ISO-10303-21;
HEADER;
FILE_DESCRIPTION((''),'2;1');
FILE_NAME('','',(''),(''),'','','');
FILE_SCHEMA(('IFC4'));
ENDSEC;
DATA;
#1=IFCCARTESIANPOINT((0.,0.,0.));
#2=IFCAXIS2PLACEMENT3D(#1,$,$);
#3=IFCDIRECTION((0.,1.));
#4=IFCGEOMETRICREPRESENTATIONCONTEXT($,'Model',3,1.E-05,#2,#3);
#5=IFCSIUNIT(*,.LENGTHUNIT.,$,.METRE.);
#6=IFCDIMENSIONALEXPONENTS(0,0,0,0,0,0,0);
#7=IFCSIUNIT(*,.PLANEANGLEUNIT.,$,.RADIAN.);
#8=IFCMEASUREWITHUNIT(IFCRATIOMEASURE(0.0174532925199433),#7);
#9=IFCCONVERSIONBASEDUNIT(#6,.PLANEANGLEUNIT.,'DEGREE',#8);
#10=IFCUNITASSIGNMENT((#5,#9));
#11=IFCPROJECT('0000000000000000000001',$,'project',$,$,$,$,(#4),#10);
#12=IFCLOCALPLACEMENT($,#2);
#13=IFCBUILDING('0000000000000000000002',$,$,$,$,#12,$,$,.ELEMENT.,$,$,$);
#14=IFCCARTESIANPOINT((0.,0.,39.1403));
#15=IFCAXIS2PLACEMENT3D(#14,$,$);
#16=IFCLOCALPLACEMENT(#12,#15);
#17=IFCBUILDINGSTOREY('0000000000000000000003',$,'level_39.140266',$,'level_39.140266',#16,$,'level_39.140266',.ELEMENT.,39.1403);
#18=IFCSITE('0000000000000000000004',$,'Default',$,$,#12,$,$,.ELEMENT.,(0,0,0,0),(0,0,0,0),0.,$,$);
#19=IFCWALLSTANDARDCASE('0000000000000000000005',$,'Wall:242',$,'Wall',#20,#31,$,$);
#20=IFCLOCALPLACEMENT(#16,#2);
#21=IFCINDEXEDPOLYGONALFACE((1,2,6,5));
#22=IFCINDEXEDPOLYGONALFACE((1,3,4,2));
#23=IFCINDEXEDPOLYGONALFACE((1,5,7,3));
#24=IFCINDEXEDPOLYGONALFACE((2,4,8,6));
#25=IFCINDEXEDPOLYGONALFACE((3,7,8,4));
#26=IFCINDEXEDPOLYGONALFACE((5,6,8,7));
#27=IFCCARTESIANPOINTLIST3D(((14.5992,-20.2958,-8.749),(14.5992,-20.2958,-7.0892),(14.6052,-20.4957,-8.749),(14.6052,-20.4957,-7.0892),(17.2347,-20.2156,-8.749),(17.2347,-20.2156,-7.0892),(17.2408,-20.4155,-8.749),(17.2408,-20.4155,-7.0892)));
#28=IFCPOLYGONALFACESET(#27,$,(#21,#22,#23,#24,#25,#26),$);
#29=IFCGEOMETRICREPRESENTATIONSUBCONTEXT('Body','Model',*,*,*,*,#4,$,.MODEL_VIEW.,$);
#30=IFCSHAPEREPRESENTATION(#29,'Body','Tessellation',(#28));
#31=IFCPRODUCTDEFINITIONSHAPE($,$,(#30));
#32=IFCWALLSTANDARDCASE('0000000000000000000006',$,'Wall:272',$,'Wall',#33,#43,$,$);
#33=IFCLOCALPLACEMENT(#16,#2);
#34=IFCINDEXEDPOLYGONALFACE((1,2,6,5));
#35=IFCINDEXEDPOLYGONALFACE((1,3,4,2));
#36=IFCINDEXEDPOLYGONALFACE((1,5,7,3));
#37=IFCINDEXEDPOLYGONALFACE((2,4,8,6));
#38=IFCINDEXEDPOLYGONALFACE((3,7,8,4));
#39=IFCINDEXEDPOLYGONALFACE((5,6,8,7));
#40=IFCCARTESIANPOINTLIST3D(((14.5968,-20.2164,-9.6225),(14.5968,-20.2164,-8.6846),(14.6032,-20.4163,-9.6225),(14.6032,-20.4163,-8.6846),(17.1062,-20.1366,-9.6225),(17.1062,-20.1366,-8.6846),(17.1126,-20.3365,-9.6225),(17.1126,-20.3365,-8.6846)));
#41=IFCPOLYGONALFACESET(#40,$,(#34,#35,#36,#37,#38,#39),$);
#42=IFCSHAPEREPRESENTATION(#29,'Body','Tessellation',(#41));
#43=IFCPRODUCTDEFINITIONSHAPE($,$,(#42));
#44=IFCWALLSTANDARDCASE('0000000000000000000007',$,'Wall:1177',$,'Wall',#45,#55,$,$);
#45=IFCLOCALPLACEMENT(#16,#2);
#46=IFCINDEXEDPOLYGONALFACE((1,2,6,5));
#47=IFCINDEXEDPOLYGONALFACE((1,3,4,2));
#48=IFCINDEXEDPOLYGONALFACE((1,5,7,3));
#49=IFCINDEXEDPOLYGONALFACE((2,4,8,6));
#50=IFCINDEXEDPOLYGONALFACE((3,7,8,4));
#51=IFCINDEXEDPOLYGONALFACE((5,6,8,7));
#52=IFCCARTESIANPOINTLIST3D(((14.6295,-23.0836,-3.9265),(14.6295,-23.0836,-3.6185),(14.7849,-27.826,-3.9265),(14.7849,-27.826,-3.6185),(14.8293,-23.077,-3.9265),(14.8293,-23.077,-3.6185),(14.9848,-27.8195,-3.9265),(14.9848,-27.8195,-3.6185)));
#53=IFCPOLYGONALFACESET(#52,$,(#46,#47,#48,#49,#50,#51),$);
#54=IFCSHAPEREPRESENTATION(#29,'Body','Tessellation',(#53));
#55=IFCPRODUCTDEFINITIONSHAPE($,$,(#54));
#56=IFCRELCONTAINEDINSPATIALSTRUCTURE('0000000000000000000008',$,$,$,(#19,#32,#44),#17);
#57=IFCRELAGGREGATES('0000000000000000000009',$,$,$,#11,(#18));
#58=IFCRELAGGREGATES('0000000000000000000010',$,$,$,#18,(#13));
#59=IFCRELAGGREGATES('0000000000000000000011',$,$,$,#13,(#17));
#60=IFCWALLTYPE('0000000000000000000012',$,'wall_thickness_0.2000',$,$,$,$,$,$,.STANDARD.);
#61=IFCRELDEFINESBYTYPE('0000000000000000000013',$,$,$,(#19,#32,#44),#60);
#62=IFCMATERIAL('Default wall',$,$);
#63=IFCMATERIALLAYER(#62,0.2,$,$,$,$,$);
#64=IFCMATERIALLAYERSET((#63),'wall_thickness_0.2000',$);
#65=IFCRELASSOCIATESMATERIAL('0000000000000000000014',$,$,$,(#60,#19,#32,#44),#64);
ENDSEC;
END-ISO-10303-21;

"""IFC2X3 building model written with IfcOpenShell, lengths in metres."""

from ifc_helpers import new_model, entity, si_unit, converted_unit, direction, frame, origin, place, context, subcontext, project, spatial, polyline, outline, extrude, material, layer, layer_set, layer_usage, type_object, element, save


model = new_model("IFC2X3")

# Units and contexts
model_context = context("Model", 3, precision=1e-05, world=origin(), true_north=direction((0.0, 1.0)))
body_context = subcontext(model_context, "Body", "Model", "MODEL_VIEW")
ifc_project = project(units=[si_unit("LENGTHUNIT", "METRE"), converted_unit("PLANEANGLEUNIT", "DEGREE", entity("IfcRatioMeasure", 0.0174532925199433), si_unit("PLANEANGLEUNIT", "RADIAN"), dimensions=[0, 0, 0, 0, 0, 0, 0])], contexts=[model_context])

# Site, building, storey
placement_1 = place(None, origin())
site = spatial("IfcSite", under=ifc_project, at=placement_1, Name="Default", CompositionType="ELEMENT", RefLatitude=(0, 0, 0, 0), RefLongitude=(0, 0, 0, 0), RefElevation=0.0)
building = spatial("IfcBuilding", under=site, at=placement_1, CompositionType="ELEMENT")
storey_placement = place(placement_1, frame((0.0, 0.0, 39.1403)))
storey = spatial("IfcBuildingStorey", under=building, at=storey_placement, Name="level_39.140266", ObjectType="level_39.140266", LongName="level_39.140266", CompositionType="ELEMENT", Elevation=39.1403)

# Walls
ifc_material = material(Name="Default wall")
ifc_layer = layer(ifc_material, 0.2)
ifc_layer_set = layer_set([ifc_layer], Name="wall_thickness_0.2000")
ifc_layer_usage = layer_usage(ifc_layer_set, "AXIS2", "POSITIVE", -0.1)
wall_type = type_object("IfcWallType", Name="wall_thickness_0.2000", PredefinedType="STANDARD", material=ifc_layer_set)
placement_2 = place(placement_1, frame((0.0, 0.0, 30.3913)))
wall_1_placement = place(placement_2, frame((14.6022, -20.3958, 0.0), z_axis=(0.0, 0.0, 1.0), x_axis=(0.999537, 0.030433, 0.0)))
element("IfcWallStandardCase", 1, at=wall_1_placement, inside=storey, type_object=wall_type, material=ifc_layer_usage, Name="Wall:242", ObjectType="Wall", context=body_context, shape_type="SweptSolid", body=[
    extrude(outline(polyline([(2.6368, -0.1), (2.6368, 0.1), (0.0, 0.1), (0.0, -0.1), (2.6368, -0.1)])), origin(), (0.0, 0.0, 1.0), 1.6598),
])
placement_3 = place(placement_1, frame((0.0, 0.0, 29.5178)))
wall_2_placement = place(placement_3, frame((14.6, -20.3164, 0.0), z_axis=(0.0, 0.0, 1.0), x_axis=(0.999495, 0.031786, 0.0)))
element("IfcWallStandardCase", 2, at=wall_2_placement, inside=storey, type_object=wall_type, material=ifc_layer_usage, Name="Wall:272", ObjectType="Wall", context=body_context, shape_type="SweptSolid", body=[
    extrude(outline(polyline([(2.5107, -0.1), (2.5107, 0.1), (0.0, 0.1), (0.0, -0.1), (2.5107, -0.1)])), origin(), (0.0, 0.0, 1.0), 0.9379),
])
placement_4 = place(placement_1, frame((0.0, 0.0, 35.2138)))
wall_3_placement = place(placement_4, frame((14.7294, -23.0803, 0.0), z_axis=(0.0, 0.0, 1.0), x_axis=(0.032768, -0.999463, 0.0)))
element("IfcWallStandardCase", 3, at=wall_3_placement, inside=storey, type_object=wall_type, material=ifc_layer_usage, Name="Wall:1177", ObjectType="Wall", context=body_context, shape_type="SweptSolid", body=[
    extrude(outline(polyline([(4.745, -0.1), (4.745, 0.1), (0.0, 0.1), (0.0, -0.1), (4.745, -0.1)])), origin(), (0.0, 0.0, 1.0), 0.308),
])

save(model, "model.ifc")
